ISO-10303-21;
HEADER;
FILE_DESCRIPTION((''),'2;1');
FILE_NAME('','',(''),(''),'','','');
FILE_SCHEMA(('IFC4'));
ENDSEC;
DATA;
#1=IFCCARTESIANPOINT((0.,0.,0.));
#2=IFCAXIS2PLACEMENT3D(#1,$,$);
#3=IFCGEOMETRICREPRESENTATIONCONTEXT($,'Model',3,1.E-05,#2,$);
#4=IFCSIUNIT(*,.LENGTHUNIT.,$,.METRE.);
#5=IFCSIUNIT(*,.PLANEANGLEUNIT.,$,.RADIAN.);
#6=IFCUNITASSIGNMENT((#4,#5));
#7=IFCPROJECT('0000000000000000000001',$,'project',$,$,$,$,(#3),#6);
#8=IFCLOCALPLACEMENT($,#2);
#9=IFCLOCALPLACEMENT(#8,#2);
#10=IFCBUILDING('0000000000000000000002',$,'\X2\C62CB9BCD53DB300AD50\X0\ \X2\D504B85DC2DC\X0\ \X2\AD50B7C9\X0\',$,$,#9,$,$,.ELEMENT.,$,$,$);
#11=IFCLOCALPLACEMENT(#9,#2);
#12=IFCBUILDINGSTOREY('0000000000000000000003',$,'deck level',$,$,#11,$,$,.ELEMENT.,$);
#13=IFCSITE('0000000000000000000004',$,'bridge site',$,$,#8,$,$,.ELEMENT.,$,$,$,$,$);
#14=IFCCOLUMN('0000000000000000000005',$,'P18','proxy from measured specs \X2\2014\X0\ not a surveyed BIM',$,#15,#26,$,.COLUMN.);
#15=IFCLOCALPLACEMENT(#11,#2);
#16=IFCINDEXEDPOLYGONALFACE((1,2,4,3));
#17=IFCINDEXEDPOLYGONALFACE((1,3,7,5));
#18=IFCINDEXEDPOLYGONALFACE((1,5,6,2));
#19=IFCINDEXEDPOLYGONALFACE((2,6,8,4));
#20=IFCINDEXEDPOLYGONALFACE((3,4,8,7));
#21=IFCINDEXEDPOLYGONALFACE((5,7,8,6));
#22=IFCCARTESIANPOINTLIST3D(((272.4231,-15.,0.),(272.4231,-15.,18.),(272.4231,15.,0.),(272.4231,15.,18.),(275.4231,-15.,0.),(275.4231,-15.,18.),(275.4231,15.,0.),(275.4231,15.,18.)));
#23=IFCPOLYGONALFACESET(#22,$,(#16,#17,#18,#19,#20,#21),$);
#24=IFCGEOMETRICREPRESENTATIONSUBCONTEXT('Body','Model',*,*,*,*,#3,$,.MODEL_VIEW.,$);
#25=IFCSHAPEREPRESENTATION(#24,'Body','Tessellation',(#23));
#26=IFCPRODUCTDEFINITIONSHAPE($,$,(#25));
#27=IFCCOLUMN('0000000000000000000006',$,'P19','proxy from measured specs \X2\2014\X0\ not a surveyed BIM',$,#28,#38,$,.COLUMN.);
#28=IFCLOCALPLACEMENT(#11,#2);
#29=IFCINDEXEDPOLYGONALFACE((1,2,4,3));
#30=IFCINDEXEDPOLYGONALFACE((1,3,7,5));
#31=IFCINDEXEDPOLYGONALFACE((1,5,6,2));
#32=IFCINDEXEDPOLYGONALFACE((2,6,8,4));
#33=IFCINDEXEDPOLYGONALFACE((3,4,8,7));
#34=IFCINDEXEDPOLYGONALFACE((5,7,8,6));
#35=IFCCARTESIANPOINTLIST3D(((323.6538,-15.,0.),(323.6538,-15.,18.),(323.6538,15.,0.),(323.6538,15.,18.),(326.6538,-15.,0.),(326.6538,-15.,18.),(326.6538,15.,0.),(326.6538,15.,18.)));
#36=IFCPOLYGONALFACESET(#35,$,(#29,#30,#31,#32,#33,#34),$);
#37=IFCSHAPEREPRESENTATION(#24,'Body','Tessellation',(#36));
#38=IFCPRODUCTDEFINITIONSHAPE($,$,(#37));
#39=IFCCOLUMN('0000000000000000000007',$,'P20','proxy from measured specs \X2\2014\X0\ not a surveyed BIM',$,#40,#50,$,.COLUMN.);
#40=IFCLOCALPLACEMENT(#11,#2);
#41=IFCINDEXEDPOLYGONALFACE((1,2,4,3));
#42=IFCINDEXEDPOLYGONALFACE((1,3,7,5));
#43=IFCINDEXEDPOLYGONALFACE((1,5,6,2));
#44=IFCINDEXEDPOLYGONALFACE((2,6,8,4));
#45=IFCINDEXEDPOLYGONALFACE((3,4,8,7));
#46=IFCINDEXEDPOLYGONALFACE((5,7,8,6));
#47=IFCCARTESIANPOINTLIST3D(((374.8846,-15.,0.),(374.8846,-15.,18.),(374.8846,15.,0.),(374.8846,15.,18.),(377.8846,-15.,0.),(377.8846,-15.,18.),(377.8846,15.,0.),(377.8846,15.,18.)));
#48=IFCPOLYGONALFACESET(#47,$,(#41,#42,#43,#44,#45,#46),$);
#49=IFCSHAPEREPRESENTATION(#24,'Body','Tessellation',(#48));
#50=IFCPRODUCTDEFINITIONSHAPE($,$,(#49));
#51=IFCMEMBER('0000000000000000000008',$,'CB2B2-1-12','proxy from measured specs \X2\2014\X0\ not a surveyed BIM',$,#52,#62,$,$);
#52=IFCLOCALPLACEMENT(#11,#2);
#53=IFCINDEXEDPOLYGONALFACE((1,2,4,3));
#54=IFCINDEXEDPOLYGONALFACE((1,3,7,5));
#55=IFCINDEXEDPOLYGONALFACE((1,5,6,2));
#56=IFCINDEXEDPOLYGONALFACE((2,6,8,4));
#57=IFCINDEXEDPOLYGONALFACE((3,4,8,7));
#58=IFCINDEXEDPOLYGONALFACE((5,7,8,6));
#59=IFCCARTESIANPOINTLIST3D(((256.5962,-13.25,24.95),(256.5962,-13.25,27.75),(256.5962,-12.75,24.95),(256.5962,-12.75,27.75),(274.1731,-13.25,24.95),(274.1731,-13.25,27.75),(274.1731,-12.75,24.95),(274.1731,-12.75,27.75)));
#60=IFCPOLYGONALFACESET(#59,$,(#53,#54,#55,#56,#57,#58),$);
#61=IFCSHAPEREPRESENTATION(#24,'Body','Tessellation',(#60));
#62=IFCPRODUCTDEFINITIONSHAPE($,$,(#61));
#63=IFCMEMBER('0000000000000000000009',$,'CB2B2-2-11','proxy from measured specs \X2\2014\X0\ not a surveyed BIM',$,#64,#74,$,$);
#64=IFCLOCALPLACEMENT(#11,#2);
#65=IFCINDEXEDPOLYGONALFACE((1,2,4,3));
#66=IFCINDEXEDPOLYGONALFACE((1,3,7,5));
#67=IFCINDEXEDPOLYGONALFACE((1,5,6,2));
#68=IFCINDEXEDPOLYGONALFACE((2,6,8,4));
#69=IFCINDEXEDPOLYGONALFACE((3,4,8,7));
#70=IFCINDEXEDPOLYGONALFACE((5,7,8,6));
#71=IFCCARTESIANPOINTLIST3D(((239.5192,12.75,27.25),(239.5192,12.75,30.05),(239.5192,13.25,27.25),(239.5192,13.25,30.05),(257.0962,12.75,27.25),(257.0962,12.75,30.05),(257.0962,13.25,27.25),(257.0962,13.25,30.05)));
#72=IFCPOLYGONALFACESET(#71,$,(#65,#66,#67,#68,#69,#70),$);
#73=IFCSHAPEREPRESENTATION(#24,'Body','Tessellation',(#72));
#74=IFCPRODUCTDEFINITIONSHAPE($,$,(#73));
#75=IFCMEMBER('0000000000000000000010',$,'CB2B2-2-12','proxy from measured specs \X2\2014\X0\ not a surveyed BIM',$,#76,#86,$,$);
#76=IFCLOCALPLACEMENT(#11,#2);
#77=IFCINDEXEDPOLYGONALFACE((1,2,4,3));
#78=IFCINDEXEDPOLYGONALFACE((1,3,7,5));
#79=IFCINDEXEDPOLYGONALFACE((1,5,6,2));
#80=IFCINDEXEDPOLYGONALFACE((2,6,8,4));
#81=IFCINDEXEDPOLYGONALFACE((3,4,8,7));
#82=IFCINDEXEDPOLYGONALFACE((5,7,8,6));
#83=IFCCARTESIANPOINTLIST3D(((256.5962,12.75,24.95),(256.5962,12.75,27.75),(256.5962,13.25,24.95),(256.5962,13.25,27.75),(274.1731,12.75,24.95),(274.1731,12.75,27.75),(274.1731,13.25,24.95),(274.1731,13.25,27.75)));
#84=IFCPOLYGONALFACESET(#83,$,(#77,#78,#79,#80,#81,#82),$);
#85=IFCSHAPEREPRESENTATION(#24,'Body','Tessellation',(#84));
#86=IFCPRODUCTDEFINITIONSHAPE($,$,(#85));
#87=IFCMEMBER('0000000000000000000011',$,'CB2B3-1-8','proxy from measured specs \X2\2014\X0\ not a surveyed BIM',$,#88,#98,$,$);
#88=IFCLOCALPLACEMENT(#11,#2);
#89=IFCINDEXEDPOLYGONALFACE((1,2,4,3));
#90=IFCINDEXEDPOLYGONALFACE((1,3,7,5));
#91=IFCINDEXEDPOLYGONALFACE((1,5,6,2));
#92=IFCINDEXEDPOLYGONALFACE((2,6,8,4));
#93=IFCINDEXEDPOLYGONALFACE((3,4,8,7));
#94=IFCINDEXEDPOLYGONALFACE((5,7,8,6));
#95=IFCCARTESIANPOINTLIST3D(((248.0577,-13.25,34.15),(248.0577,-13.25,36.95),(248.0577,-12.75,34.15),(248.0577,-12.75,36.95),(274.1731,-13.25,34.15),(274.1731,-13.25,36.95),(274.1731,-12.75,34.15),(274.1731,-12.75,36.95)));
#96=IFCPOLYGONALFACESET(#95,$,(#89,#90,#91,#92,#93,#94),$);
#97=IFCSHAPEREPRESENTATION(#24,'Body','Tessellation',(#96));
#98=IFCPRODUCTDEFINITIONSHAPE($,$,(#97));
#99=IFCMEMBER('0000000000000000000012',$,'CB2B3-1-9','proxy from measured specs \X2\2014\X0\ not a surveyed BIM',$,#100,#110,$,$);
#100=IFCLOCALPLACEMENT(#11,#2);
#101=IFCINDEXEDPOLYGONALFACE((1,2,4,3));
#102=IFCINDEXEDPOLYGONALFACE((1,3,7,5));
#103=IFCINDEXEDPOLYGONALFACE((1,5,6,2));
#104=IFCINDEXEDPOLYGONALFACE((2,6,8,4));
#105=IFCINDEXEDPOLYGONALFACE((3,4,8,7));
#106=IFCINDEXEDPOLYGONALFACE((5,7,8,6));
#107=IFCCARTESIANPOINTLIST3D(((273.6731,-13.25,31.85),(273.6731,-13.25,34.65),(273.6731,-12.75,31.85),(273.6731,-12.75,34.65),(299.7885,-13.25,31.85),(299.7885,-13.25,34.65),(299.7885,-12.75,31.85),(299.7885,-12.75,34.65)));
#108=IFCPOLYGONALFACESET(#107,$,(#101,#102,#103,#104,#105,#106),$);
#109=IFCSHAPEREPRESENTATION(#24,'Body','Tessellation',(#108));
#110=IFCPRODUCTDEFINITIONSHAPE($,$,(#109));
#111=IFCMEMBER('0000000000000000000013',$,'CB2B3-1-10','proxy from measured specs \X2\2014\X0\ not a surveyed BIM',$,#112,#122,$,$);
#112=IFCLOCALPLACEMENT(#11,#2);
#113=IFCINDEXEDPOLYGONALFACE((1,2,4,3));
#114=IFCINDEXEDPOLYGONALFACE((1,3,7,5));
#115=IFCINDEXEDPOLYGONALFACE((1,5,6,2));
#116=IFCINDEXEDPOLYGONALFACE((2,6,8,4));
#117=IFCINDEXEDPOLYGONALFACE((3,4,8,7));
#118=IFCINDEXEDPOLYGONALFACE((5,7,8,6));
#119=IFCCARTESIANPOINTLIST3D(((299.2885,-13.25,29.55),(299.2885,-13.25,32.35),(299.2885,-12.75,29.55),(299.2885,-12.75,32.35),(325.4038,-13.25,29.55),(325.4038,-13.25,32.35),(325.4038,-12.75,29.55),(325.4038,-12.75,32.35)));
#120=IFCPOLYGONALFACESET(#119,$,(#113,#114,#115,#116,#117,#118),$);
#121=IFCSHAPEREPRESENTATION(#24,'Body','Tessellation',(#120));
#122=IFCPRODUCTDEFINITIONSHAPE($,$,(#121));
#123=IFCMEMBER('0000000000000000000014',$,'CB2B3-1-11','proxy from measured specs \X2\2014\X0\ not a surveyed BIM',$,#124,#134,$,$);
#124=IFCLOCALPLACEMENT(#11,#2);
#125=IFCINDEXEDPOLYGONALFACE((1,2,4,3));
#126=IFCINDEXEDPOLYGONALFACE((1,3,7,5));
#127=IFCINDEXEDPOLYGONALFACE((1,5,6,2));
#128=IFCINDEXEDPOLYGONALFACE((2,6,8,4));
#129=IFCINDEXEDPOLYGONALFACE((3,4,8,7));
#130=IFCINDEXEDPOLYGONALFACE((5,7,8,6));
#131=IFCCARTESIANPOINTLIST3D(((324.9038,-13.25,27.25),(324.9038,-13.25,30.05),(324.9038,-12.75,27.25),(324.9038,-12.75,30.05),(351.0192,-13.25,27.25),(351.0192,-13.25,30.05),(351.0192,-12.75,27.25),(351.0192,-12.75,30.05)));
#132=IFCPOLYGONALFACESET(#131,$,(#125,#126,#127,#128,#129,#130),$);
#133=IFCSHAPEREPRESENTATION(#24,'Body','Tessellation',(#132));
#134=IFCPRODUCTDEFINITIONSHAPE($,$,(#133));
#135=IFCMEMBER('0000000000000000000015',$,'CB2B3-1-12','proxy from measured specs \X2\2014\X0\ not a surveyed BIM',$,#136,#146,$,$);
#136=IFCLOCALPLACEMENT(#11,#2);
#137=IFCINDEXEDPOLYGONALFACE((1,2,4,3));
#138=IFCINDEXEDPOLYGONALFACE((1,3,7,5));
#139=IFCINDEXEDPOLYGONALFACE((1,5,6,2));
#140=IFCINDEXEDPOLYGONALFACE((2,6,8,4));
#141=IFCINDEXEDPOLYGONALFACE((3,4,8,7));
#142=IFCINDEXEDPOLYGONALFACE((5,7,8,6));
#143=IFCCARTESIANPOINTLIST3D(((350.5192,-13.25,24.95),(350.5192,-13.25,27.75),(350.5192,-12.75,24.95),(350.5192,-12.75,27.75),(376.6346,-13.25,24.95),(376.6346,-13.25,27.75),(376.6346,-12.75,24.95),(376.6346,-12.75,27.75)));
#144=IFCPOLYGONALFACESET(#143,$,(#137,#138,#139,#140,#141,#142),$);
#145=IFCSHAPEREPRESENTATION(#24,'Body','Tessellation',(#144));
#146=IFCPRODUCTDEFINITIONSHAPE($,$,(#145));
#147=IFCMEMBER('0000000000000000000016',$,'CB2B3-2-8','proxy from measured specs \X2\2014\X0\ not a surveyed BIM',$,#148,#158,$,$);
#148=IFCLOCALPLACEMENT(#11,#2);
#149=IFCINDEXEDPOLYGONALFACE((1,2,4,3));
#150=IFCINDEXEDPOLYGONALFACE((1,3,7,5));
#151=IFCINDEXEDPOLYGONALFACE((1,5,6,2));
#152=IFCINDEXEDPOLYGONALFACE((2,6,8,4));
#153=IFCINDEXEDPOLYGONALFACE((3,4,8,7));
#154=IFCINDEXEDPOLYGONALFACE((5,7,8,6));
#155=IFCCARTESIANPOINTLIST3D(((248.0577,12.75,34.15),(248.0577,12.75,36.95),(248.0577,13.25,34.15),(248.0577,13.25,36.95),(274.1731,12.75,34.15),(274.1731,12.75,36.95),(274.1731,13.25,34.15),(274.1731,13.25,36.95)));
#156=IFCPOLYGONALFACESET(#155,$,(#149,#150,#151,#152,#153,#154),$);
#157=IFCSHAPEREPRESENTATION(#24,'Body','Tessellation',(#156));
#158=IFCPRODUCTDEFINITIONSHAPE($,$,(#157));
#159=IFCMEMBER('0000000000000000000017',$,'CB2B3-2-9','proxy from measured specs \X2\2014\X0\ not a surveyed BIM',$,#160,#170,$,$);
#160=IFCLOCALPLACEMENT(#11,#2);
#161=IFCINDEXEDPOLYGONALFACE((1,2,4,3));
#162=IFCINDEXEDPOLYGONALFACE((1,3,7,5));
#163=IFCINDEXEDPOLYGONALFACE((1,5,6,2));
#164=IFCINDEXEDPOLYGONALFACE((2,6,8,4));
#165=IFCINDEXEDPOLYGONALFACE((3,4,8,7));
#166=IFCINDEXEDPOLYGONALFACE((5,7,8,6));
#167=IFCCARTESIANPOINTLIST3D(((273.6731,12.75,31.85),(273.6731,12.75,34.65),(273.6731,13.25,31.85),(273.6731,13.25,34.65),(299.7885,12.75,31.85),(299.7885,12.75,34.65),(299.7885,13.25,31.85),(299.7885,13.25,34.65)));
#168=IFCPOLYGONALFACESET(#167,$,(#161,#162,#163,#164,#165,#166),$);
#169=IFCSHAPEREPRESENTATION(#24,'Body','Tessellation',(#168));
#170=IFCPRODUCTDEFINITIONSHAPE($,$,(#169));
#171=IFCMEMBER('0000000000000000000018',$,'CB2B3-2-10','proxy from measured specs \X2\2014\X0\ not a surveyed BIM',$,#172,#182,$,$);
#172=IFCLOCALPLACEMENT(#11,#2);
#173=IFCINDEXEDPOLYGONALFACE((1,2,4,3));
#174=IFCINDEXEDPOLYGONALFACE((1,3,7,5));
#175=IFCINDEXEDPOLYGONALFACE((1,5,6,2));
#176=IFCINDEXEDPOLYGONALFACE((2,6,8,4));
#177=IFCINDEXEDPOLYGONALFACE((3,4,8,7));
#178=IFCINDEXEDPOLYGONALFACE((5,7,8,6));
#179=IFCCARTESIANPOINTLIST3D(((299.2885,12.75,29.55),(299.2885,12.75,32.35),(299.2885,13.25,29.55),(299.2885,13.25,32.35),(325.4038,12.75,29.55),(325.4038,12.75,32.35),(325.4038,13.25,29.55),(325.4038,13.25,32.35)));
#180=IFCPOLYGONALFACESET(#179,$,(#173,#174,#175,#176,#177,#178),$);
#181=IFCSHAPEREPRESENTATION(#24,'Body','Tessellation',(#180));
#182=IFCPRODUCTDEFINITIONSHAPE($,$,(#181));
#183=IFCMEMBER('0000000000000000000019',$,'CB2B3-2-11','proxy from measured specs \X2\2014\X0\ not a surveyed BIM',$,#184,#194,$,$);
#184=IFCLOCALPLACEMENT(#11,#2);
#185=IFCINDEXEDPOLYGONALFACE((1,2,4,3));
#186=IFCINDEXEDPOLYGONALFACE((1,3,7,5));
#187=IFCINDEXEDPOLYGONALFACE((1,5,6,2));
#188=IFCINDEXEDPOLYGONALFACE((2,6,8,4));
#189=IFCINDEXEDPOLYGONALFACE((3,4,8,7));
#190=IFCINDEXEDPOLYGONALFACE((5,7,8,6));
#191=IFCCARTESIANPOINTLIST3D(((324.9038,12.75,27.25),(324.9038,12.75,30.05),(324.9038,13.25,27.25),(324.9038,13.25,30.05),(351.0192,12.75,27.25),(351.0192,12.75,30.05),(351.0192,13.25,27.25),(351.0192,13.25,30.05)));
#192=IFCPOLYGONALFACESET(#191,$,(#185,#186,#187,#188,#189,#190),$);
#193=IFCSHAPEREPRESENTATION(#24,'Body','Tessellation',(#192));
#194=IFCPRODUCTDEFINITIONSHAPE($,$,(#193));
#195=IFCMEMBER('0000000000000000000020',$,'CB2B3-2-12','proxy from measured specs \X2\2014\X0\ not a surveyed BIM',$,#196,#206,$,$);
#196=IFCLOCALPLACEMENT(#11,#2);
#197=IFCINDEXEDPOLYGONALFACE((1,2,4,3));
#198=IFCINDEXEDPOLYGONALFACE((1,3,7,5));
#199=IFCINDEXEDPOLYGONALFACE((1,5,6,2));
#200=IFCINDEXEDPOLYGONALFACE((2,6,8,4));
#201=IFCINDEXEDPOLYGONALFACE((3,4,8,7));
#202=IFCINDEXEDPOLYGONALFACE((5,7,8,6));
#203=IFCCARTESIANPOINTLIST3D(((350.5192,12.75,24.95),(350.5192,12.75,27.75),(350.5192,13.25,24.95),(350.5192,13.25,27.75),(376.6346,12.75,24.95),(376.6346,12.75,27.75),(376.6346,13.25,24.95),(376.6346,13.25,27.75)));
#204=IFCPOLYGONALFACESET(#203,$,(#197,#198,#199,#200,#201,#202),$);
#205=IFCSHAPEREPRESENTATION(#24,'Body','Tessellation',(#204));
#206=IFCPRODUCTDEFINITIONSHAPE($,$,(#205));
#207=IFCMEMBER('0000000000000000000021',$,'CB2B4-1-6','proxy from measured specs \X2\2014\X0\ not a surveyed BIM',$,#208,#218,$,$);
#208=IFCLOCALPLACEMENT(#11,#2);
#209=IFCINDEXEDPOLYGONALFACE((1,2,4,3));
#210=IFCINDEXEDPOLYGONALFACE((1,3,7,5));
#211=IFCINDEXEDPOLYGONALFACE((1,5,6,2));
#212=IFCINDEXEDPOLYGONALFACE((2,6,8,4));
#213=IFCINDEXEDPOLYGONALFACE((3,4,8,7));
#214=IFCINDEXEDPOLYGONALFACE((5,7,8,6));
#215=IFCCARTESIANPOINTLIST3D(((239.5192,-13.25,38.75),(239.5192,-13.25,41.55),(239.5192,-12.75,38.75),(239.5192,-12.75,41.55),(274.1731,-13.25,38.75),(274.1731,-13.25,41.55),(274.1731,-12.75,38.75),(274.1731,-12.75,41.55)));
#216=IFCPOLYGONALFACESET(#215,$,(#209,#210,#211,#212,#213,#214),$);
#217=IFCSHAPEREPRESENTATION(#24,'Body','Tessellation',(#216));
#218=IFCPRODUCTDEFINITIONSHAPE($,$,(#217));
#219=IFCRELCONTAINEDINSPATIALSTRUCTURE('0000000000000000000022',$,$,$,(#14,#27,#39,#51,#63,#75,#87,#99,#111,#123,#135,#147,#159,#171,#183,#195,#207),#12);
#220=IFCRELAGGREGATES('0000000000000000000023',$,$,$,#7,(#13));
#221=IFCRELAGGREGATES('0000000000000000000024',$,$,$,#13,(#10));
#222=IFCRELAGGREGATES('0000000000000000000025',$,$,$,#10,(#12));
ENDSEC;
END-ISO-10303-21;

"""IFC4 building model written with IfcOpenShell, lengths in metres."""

from ifc_helpers import new_model, si_unit, frame, origin, origin_2d, place, context, subcontext, project, spatial, rectangle, extrude, element, save


model = new_model("IFC4")

# Units and contexts
model_context = context("Model", 3, precision=1e-05, world=origin())
body_context = subcontext(model_context, "Body", "Model", "MODEL_VIEW")
ifc_project = project(units=[si_unit("LENGTHUNIT", "METRE"), si_unit("PLANEANGLEUNIT", "RADIAN")], contexts=[model_context])

# Site, building, storey
site_placement = place(None, origin())
site = spatial("IfcSite", under=ifc_project, at=site_placement, Name="bridge site", CompositionType="ELEMENT")
building_placement = place(site_placement, origin())
building = spatial("IfcBuilding", under=site, at=building_placement, Name="올림픽대교 프록시 교량", CompositionType="ELEMENT")
storey_placement = place(building_placement, origin())
storey = spatial("IfcBuildingStorey", under=building, at=storey_placement, Name="deck level", CompositionType="ELEMENT")

# Columns
for number, where, name in (
    (1, (273.9231, 0.0, 0.0), "P18"),
    (2, (325.1538, 0.0, 0.0), "P19"),
    (3, (376.3846, 0.0, 0.0), "P20"),
):
    element("IfcColumn", number, at=place(storey_placement, frame(where)), inside=storey, Name=name, Description="proxy from measured specs — not a surveyed BIM", PredefinedType="COLUMN", context=body_context, shape_type="SweptSolid", body=[
        extrude(rectangle(XDim=3.0, YDim=30.0, at=origin_2d()), origin(), (0.0, 0.0, 1.0), 18.0),
    ])

# Members
member_1_placement = place(storey_placement, frame((265.3846, -13.0, 24.95)))
element("IfcMember", 4, at=member_1_placement, inside=storey, Name="CB2B2-1-12", Description="proxy from measured specs — not a surveyed BIM", context=body_context, shape_type="SweptSolid", body=[
    extrude(rectangle(XDim=17.5769, YDim=0.5, at=origin_2d()), origin(), (0.0, 0.0, 1.0), 2.8),
])
member_2_placement = place(storey_placement, frame((248.3077, 13.0, 27.25)))
element("IfcMember", 5, at=member_2_placement, inside=storey, Name="CB2B2-2-11", Description="proxy from measured specs — not a surveyed BIM", context=body_context, shape_type="SweptSolid", body=[
    extrude(rectangle(XDim=17.5769, YDim=0.5, at=origin_2d()), origin(), (0.0, 0.0, 1.0), 2.8),
])
member_3_placement = place(storey_placement, frame((265.3846, 13.0, 24.95)))
element("IfcMember", 6, at=member_3_placement, inside=storey, Name="CB2B2-2-12", Description="proxy from measured specs — not a surveyed BIM", context=body_context, shape_type="SweptSolid", body=[
    extrude(rectangle(XDim=17.5769, YDim=0.5, at=origin_2d()), origin(), (0.0, 0.0, 1.0), 2.8),
])
member_4_placement = place(storey_placement, frame((261.1154, -13.0, 34.15)))
element("IfcMember", 7, at=member_4_placement, inside=storey, Name="CB2B3-1-8", Description="proxy from measured specs — not a surveyed BIM", context=body_context, shape_type="SweptSolid", body=[
    extrude(rectangle(XDim=26.1154, YDim=0.5, at=origin_2d()), origin(), (0.0, 0.0, 1.0), 2.8),
])
member_5_placement = place(storey_placement, frame((286.7308, -13.0, 31.85)))
element("IfcMember", 8, at=member_5_placement, inside=storey, Name="CB2B3-1-9", Description="proxy from measured specs — not a surveyed BIM", context=body_context, shape_type="SweptSolid", body=[
    extrude(rectangle(XDim=26.1154, YDim=0.5, at=origin_2d()), origin(), (0.0, 0.0, 1.0), 2.8),
])
member_6_placement = place(storey_placement, frame((312.3462, -13.0, 29.55)))
element("IfcMember", 9, at=member_6_placement, inside=storey, Name="CB2B3-1-10", Description="proxy from measured specs — not a surveyed BIM", context=body_context, shape_type="SweptSolid", body=[
    extrude(rectangle(XDim=26.1154, YDim=0.5, at=origin_2d()), origin(), (0.0, 0.0, 1.0), 2.8),
])
member_7_placement = place(storey_placement, frame((337.9615, -13.0, 27.25)))
element("IfcMember", 10, at=member_7_placement, inside=storey, Name="CB2B3-1-11", Description="proxy from measured specs — not a surveyed BIM", context=body_context, shape_type="SweptSolid", body=[
    extrude(rectangle(XDim=26.1154, YDim=0.5, at=origin_2d()), origin(), (0.0, 0.0, 1.0), 2.8),
])
member_8_placement = place(storey_placement, frame((363.5769, -13.0, 24.95)))
element("IfcMember", 11, at=member_8_placement, inside=storey, Name="CB2B3-1-12", Description="proxy from measured specs — not a surveyed BIM", context=body_context, shape_type="SweptSolid", body=[
    extrude(rectangle(XDim=26.1154, YDim=0.5, at=origin_2d()), origin(), (0.0, 0.0, 1.0), 2.8),
])
member_9_placement = place(storey_placement, frame((261.1154, 13.0, 34.15)))
element("IfcMember", 12, at=member_9_placement, inside=storey, Name="CB2B3-2-8", Description="proxy from measured specs — not a surveyed BIM", context=body_context, shape_type="SweptSolid", body=[
    extrude(rectangle(XDim=26.1154, YDim=0.5, at=origin_2d()), origin(), (0.0, 0.0, 1.0), 2.8),
])
member_10_placement = place(storey_placement, frame((286.7308, 13.0, 31.85)))
element("IfcMember", 13, at=member_10_placement, inside=storey, Name="CB2B3-2-9", Description="proxy from measured specs — not a surveyed BIM", context=body_context, shape_type="SweptSolid", body=[
    extrude(rectangle(XDim=26.1154, YDim=0.5, at=origin_2d()), origin(), (0.0, 0.0, 1.0), 2.8),
])
member_11_placement = place(storey_placement, frame((312.3462, 13.0, 29.55)))
element("IfcMember", 14, at=member_11_placement, inside=storey, Name="CB2B3-2-10", Description="proxy from measured specs — not a surveyed BIM", context=body_context, shape_type="SweptSolid", body=[
    extrude(rectangle(XDim=26.1154, YDim=0.5, at=origin_2d()), origin(), (0.0, 0.0, 1.0), 2.8),
])
member_12_placement = place(storey_placement, frame((337.9615, 13.0, 27.25)))
element("IfcMember", 15, at=member_12_placement, inside=storey, Name="CB2B3-2-11", Description="proxy from measured specs — not a surveyed BIM", context=body_context, shape_type="SweptSolid", body=[
    extrude(rectangle(XDim=26.1154, YDim=0.5, at=origin_2d()), origin(), (0.0, 0.0, 1.0), 2.8),
])
member_13_placement = place(storey_placement, frame((363.5769, 13.0, 24.95)))
element("IfcMember", 16, at=member_13_placement, inside=storey, Name="CB2B3-2-12", Description="proxy from measured specs — not a surveyed BIM", context=body_context, shape_type="SweptSolid", body=[
    extrude(rectangle(XDim=26.1154, YDim=0.5, at=origin_2d()), origin(), (0.0, 0.0, 1.0), 2.8),
])
member_14_placement = place(storey_placement, frame((256.8462, -13.0, 38.75)))
element("IfcMember", 17, at=member_14_placement, inside=storey, Name="CB2B4-1-6", Description="proxy from measured specs — not a surveyed BIM", context=body_context, shape_type="SweptSolid", body=[
    extrude(rectangle(XDim=34.6538, YDim=0.5, at=origin_2d()), origin(), (0.0, 0.0, 1.0), 2.8),
])

save(model, "model.ifc")
